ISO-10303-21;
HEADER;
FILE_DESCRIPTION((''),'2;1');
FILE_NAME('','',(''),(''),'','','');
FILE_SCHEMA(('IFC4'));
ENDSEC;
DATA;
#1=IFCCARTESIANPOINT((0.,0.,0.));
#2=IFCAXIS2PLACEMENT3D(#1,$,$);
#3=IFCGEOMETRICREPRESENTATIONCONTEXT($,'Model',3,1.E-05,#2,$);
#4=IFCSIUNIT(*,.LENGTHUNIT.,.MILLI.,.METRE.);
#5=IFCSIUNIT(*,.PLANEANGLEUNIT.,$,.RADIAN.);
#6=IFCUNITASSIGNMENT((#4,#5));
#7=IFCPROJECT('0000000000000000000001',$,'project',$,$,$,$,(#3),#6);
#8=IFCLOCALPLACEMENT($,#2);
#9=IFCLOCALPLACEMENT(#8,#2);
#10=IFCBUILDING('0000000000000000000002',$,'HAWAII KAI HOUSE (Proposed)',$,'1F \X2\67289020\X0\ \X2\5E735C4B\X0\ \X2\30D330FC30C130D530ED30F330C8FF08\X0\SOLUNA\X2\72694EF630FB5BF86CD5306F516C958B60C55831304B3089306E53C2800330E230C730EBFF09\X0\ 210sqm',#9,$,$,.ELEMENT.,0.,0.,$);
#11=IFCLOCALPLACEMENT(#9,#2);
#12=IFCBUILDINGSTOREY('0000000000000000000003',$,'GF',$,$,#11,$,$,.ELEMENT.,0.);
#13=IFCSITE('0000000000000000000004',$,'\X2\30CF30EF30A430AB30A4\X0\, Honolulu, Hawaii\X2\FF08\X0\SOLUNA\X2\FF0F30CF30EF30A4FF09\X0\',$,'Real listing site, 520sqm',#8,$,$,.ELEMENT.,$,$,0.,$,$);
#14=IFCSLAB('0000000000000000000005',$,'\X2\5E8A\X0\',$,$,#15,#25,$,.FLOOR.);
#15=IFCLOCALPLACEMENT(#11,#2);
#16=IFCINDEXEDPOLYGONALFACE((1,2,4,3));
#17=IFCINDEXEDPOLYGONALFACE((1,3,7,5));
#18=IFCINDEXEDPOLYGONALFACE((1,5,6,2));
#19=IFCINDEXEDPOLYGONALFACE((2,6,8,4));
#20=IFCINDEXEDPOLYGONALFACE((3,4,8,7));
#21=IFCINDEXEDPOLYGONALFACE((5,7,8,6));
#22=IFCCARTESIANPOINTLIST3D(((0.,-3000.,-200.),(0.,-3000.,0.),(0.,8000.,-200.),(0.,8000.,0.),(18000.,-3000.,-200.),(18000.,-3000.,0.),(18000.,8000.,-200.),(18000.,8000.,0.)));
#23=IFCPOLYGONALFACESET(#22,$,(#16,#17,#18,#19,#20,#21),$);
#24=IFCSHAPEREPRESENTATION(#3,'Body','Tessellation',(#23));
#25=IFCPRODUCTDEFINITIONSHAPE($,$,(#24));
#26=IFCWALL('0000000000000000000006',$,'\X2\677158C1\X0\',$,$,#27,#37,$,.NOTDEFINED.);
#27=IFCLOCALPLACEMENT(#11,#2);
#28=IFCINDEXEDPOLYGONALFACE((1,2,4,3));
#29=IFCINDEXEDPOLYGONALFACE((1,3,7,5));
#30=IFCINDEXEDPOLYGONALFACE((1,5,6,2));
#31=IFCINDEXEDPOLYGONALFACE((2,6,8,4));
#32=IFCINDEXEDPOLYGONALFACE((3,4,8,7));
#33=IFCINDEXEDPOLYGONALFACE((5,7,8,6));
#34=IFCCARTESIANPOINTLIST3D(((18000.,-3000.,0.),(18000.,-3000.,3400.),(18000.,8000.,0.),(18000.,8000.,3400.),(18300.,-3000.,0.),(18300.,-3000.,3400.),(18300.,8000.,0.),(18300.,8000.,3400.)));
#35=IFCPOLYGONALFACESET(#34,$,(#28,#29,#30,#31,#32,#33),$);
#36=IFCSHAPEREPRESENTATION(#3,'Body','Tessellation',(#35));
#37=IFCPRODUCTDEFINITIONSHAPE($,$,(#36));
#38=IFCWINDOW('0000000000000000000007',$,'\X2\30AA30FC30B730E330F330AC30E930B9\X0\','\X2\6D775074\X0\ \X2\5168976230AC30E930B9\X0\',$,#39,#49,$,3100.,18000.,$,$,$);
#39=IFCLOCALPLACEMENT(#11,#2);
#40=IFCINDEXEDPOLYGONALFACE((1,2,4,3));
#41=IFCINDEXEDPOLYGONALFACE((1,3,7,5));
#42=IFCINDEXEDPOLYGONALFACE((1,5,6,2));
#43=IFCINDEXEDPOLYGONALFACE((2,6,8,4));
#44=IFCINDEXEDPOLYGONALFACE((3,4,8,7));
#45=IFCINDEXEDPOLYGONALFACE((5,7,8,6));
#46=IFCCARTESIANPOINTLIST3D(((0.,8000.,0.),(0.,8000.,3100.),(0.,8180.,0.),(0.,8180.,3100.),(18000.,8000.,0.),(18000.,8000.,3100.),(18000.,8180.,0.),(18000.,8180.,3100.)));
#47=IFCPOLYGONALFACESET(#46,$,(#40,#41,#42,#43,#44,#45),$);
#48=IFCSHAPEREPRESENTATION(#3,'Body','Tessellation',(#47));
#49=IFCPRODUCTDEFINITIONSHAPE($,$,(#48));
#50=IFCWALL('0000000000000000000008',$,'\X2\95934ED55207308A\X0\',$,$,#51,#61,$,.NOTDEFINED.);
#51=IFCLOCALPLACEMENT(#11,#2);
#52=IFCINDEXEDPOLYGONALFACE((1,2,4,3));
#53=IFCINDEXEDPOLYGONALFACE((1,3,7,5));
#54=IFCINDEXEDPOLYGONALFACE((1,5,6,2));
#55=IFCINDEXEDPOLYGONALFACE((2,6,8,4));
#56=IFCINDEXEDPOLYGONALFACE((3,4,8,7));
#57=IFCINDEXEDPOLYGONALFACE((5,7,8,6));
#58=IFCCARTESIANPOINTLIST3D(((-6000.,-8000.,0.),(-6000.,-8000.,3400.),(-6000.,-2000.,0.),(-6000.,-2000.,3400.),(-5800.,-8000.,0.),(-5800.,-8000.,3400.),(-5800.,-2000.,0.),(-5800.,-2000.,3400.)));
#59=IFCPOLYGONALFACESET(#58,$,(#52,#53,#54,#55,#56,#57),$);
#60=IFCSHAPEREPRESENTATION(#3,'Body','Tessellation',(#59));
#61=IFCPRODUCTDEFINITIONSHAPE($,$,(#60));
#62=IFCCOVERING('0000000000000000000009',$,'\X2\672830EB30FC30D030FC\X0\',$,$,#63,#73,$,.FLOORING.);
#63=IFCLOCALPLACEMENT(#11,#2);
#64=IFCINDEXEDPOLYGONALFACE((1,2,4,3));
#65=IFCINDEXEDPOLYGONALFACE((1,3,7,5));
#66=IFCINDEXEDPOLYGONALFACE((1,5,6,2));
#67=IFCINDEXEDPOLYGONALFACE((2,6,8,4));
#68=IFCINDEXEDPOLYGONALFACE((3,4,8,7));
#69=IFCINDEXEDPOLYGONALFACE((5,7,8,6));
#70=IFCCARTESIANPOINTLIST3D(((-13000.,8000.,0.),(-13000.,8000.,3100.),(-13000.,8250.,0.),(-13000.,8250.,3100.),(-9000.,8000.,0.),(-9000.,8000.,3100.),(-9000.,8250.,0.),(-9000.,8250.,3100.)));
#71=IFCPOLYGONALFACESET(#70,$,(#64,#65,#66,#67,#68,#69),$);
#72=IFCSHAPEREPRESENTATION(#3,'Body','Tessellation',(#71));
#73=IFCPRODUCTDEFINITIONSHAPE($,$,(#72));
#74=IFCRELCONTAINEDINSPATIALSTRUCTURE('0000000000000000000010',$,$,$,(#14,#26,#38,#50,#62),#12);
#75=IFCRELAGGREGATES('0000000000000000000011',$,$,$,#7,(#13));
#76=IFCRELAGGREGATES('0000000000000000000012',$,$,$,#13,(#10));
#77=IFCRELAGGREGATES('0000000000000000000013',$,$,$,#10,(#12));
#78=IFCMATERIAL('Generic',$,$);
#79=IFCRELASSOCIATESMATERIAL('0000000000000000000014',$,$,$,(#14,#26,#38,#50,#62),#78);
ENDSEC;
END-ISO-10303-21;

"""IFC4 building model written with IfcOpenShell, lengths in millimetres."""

from ifc_helpers import new_model, si_unit, frame, frame_2d, origin, place, context, project, spatial, rectangle, extrude, material, element, fill, save


model = new_model("IFC4")

# Units and contexts
model_context = context("Model", 3, precision=1e-05, world=origin())
ifc_project = project(units=[si_unit("LENGTHUNIT", "METRE", prefix="MILLI"), si_unit("PLANEANGLEUNIT", "RADIAN")], contexts=[model_context])

# Site, building, storey
site_placement = place(None, origin())
site = spatial("IfcSite", under=ifc_project, at=site_placement, Name="ハワイカイ, Honolulu, Hawaii（SOLUNA／ハワイ）", ObjectType="Real listing site, 520sqm", CompositionType="ELEMENT", RefElevation=0.0)
building_placement = place(site_placement, origin())
building = spatial("IfcBuilding", under=site, at=building_placement, Name="HAWAII KAI HOUSE (Proposed)", ObjectType="1F 木造 平屋 ビーチフロント（SOLUNA物件・寸法は公開情報からの参考モデル） 210sqm", CompositionType="ELEMENT", ElevationOfRefHeight=0.0, ElevationOfTerrain=0.0)
storey_placement = place(building_placement, origin())
storey = spatial("IfcBuildingStorey", under=building, at=storey_placement, Name="GF", CompositionType="ELEMENT", Elevation=0.0)

# Shared definitions
ifc_material_1 = material(Name="Generic")

# Slab
slab_1_placement = place(storey_placement, frame((0.0, -1500.0, -100.0)))
element("IfcSlab", 1, at=slab_1_placement, inside=storey, material=ifc_material_1, Name="床", PredefinedType="FLOOR", context=model_context, shape_type="SweptSolid", body=[
    extrude(rectangle(XDim=18000.0, YDim=11000.0, at=frame_2d((9000.0, 5500.0))), frame((0.0, -1500.0, -100.0)), (0.0, 0.0, 1.0), 200.0),
])

# Wall, opening, window
wall_1_placement = place(storey_placement, frame((9000.0, -1500.0, 0.0)))
wall_1 = element("IfcWall", 2, at=wall_1_placement, inside=storey, material=ifc_material_1, Name="東壁", PredefinedType="NOTDEFINED", context=model_context, shape_type="SweptSolid", body=[
    extrude(rectangle(XDim=300.0, YDim=11000.0, at=frame_2d((150.0, 5500.0))), frame((9000.0, -1500.0, 0.0)), (0.0, 0.0, 1.0), 3400.0),
])
opening_placement = place(storey_placement, frame((0.0, 4000.0, 0.0)))
opening = element("IfcOpeningElement", 3, at=opening_placement, cuts=wall_1, PredefinedType="NOTDEFINED", context=model_context, shape_type="SweptSolid", body=[
    extrude(rectangle(XDim=18000.0, YDim=180.0, at=frame_2d((9000.0, 90.0))), frame((0.0, 4000.0, 0.0)), (0.0, 0.0, 1.0), 3100.0),
])
window_placement = place(storey_placement, frame((0.0, 4000.0, 0.0)))
window = element("IfcWindow", 4, at=window_placement, inside=storey, material=ifc_material_1, Name="オーシャンガラス", Description="海側 全面ガラス", OverallHeight=3100.0, OverallWidth=18000.0, context=model_context, shape_type="SweptSolid", body=[
    extrude(rectangle(XDim=18000.0, YDim=180.0, at=frame_2d((9000.0, 90.0))), frame((0.0, 4000.0, 0.0)), (0.0, 0.0, 1.0), 3100.0),
])
fill(opening, window)

# Wall
wall_2_placement = place(storey_placement, frame((-3000.0, -4000.0, 0.0)))
element("IfcWall", 5, at=wall_2_placement, inside=storey, material=ifc_material_1, Name="間仕切り", PredefinedType="NOTDEFINED", context=model_context, shape_type="SweptSolid", body=[
    extrude(rectangle(XDim=200.0, YDim=6000.0, at=frame_2d((100.0, 3000.0))), frame((-3000.0, -4000.0, 0.0)), (0.0, 0.0, 1.0), 3400.0),
])

# Covering
covering_placement = place(storey_placement, frame((-6500.0, 4000.0, 0.0)))
element("IfcCovering", 6, at=covering_placement, inside=storey, material=ifc_material_1, Name="木ルーバー", PredefinedType="FLOORING", context=model_context, shape_type="SweptSolid", body=[
    extrude(rectangle(XDim=4000.0, YDim=250.0, at=frame_2d((2000.0, 125.0))), frame((-6500.0, 4000.0, 0.0)), (0.0, 0.0, 1.0), 3100.0),
])

save(model, "model.ifc")
